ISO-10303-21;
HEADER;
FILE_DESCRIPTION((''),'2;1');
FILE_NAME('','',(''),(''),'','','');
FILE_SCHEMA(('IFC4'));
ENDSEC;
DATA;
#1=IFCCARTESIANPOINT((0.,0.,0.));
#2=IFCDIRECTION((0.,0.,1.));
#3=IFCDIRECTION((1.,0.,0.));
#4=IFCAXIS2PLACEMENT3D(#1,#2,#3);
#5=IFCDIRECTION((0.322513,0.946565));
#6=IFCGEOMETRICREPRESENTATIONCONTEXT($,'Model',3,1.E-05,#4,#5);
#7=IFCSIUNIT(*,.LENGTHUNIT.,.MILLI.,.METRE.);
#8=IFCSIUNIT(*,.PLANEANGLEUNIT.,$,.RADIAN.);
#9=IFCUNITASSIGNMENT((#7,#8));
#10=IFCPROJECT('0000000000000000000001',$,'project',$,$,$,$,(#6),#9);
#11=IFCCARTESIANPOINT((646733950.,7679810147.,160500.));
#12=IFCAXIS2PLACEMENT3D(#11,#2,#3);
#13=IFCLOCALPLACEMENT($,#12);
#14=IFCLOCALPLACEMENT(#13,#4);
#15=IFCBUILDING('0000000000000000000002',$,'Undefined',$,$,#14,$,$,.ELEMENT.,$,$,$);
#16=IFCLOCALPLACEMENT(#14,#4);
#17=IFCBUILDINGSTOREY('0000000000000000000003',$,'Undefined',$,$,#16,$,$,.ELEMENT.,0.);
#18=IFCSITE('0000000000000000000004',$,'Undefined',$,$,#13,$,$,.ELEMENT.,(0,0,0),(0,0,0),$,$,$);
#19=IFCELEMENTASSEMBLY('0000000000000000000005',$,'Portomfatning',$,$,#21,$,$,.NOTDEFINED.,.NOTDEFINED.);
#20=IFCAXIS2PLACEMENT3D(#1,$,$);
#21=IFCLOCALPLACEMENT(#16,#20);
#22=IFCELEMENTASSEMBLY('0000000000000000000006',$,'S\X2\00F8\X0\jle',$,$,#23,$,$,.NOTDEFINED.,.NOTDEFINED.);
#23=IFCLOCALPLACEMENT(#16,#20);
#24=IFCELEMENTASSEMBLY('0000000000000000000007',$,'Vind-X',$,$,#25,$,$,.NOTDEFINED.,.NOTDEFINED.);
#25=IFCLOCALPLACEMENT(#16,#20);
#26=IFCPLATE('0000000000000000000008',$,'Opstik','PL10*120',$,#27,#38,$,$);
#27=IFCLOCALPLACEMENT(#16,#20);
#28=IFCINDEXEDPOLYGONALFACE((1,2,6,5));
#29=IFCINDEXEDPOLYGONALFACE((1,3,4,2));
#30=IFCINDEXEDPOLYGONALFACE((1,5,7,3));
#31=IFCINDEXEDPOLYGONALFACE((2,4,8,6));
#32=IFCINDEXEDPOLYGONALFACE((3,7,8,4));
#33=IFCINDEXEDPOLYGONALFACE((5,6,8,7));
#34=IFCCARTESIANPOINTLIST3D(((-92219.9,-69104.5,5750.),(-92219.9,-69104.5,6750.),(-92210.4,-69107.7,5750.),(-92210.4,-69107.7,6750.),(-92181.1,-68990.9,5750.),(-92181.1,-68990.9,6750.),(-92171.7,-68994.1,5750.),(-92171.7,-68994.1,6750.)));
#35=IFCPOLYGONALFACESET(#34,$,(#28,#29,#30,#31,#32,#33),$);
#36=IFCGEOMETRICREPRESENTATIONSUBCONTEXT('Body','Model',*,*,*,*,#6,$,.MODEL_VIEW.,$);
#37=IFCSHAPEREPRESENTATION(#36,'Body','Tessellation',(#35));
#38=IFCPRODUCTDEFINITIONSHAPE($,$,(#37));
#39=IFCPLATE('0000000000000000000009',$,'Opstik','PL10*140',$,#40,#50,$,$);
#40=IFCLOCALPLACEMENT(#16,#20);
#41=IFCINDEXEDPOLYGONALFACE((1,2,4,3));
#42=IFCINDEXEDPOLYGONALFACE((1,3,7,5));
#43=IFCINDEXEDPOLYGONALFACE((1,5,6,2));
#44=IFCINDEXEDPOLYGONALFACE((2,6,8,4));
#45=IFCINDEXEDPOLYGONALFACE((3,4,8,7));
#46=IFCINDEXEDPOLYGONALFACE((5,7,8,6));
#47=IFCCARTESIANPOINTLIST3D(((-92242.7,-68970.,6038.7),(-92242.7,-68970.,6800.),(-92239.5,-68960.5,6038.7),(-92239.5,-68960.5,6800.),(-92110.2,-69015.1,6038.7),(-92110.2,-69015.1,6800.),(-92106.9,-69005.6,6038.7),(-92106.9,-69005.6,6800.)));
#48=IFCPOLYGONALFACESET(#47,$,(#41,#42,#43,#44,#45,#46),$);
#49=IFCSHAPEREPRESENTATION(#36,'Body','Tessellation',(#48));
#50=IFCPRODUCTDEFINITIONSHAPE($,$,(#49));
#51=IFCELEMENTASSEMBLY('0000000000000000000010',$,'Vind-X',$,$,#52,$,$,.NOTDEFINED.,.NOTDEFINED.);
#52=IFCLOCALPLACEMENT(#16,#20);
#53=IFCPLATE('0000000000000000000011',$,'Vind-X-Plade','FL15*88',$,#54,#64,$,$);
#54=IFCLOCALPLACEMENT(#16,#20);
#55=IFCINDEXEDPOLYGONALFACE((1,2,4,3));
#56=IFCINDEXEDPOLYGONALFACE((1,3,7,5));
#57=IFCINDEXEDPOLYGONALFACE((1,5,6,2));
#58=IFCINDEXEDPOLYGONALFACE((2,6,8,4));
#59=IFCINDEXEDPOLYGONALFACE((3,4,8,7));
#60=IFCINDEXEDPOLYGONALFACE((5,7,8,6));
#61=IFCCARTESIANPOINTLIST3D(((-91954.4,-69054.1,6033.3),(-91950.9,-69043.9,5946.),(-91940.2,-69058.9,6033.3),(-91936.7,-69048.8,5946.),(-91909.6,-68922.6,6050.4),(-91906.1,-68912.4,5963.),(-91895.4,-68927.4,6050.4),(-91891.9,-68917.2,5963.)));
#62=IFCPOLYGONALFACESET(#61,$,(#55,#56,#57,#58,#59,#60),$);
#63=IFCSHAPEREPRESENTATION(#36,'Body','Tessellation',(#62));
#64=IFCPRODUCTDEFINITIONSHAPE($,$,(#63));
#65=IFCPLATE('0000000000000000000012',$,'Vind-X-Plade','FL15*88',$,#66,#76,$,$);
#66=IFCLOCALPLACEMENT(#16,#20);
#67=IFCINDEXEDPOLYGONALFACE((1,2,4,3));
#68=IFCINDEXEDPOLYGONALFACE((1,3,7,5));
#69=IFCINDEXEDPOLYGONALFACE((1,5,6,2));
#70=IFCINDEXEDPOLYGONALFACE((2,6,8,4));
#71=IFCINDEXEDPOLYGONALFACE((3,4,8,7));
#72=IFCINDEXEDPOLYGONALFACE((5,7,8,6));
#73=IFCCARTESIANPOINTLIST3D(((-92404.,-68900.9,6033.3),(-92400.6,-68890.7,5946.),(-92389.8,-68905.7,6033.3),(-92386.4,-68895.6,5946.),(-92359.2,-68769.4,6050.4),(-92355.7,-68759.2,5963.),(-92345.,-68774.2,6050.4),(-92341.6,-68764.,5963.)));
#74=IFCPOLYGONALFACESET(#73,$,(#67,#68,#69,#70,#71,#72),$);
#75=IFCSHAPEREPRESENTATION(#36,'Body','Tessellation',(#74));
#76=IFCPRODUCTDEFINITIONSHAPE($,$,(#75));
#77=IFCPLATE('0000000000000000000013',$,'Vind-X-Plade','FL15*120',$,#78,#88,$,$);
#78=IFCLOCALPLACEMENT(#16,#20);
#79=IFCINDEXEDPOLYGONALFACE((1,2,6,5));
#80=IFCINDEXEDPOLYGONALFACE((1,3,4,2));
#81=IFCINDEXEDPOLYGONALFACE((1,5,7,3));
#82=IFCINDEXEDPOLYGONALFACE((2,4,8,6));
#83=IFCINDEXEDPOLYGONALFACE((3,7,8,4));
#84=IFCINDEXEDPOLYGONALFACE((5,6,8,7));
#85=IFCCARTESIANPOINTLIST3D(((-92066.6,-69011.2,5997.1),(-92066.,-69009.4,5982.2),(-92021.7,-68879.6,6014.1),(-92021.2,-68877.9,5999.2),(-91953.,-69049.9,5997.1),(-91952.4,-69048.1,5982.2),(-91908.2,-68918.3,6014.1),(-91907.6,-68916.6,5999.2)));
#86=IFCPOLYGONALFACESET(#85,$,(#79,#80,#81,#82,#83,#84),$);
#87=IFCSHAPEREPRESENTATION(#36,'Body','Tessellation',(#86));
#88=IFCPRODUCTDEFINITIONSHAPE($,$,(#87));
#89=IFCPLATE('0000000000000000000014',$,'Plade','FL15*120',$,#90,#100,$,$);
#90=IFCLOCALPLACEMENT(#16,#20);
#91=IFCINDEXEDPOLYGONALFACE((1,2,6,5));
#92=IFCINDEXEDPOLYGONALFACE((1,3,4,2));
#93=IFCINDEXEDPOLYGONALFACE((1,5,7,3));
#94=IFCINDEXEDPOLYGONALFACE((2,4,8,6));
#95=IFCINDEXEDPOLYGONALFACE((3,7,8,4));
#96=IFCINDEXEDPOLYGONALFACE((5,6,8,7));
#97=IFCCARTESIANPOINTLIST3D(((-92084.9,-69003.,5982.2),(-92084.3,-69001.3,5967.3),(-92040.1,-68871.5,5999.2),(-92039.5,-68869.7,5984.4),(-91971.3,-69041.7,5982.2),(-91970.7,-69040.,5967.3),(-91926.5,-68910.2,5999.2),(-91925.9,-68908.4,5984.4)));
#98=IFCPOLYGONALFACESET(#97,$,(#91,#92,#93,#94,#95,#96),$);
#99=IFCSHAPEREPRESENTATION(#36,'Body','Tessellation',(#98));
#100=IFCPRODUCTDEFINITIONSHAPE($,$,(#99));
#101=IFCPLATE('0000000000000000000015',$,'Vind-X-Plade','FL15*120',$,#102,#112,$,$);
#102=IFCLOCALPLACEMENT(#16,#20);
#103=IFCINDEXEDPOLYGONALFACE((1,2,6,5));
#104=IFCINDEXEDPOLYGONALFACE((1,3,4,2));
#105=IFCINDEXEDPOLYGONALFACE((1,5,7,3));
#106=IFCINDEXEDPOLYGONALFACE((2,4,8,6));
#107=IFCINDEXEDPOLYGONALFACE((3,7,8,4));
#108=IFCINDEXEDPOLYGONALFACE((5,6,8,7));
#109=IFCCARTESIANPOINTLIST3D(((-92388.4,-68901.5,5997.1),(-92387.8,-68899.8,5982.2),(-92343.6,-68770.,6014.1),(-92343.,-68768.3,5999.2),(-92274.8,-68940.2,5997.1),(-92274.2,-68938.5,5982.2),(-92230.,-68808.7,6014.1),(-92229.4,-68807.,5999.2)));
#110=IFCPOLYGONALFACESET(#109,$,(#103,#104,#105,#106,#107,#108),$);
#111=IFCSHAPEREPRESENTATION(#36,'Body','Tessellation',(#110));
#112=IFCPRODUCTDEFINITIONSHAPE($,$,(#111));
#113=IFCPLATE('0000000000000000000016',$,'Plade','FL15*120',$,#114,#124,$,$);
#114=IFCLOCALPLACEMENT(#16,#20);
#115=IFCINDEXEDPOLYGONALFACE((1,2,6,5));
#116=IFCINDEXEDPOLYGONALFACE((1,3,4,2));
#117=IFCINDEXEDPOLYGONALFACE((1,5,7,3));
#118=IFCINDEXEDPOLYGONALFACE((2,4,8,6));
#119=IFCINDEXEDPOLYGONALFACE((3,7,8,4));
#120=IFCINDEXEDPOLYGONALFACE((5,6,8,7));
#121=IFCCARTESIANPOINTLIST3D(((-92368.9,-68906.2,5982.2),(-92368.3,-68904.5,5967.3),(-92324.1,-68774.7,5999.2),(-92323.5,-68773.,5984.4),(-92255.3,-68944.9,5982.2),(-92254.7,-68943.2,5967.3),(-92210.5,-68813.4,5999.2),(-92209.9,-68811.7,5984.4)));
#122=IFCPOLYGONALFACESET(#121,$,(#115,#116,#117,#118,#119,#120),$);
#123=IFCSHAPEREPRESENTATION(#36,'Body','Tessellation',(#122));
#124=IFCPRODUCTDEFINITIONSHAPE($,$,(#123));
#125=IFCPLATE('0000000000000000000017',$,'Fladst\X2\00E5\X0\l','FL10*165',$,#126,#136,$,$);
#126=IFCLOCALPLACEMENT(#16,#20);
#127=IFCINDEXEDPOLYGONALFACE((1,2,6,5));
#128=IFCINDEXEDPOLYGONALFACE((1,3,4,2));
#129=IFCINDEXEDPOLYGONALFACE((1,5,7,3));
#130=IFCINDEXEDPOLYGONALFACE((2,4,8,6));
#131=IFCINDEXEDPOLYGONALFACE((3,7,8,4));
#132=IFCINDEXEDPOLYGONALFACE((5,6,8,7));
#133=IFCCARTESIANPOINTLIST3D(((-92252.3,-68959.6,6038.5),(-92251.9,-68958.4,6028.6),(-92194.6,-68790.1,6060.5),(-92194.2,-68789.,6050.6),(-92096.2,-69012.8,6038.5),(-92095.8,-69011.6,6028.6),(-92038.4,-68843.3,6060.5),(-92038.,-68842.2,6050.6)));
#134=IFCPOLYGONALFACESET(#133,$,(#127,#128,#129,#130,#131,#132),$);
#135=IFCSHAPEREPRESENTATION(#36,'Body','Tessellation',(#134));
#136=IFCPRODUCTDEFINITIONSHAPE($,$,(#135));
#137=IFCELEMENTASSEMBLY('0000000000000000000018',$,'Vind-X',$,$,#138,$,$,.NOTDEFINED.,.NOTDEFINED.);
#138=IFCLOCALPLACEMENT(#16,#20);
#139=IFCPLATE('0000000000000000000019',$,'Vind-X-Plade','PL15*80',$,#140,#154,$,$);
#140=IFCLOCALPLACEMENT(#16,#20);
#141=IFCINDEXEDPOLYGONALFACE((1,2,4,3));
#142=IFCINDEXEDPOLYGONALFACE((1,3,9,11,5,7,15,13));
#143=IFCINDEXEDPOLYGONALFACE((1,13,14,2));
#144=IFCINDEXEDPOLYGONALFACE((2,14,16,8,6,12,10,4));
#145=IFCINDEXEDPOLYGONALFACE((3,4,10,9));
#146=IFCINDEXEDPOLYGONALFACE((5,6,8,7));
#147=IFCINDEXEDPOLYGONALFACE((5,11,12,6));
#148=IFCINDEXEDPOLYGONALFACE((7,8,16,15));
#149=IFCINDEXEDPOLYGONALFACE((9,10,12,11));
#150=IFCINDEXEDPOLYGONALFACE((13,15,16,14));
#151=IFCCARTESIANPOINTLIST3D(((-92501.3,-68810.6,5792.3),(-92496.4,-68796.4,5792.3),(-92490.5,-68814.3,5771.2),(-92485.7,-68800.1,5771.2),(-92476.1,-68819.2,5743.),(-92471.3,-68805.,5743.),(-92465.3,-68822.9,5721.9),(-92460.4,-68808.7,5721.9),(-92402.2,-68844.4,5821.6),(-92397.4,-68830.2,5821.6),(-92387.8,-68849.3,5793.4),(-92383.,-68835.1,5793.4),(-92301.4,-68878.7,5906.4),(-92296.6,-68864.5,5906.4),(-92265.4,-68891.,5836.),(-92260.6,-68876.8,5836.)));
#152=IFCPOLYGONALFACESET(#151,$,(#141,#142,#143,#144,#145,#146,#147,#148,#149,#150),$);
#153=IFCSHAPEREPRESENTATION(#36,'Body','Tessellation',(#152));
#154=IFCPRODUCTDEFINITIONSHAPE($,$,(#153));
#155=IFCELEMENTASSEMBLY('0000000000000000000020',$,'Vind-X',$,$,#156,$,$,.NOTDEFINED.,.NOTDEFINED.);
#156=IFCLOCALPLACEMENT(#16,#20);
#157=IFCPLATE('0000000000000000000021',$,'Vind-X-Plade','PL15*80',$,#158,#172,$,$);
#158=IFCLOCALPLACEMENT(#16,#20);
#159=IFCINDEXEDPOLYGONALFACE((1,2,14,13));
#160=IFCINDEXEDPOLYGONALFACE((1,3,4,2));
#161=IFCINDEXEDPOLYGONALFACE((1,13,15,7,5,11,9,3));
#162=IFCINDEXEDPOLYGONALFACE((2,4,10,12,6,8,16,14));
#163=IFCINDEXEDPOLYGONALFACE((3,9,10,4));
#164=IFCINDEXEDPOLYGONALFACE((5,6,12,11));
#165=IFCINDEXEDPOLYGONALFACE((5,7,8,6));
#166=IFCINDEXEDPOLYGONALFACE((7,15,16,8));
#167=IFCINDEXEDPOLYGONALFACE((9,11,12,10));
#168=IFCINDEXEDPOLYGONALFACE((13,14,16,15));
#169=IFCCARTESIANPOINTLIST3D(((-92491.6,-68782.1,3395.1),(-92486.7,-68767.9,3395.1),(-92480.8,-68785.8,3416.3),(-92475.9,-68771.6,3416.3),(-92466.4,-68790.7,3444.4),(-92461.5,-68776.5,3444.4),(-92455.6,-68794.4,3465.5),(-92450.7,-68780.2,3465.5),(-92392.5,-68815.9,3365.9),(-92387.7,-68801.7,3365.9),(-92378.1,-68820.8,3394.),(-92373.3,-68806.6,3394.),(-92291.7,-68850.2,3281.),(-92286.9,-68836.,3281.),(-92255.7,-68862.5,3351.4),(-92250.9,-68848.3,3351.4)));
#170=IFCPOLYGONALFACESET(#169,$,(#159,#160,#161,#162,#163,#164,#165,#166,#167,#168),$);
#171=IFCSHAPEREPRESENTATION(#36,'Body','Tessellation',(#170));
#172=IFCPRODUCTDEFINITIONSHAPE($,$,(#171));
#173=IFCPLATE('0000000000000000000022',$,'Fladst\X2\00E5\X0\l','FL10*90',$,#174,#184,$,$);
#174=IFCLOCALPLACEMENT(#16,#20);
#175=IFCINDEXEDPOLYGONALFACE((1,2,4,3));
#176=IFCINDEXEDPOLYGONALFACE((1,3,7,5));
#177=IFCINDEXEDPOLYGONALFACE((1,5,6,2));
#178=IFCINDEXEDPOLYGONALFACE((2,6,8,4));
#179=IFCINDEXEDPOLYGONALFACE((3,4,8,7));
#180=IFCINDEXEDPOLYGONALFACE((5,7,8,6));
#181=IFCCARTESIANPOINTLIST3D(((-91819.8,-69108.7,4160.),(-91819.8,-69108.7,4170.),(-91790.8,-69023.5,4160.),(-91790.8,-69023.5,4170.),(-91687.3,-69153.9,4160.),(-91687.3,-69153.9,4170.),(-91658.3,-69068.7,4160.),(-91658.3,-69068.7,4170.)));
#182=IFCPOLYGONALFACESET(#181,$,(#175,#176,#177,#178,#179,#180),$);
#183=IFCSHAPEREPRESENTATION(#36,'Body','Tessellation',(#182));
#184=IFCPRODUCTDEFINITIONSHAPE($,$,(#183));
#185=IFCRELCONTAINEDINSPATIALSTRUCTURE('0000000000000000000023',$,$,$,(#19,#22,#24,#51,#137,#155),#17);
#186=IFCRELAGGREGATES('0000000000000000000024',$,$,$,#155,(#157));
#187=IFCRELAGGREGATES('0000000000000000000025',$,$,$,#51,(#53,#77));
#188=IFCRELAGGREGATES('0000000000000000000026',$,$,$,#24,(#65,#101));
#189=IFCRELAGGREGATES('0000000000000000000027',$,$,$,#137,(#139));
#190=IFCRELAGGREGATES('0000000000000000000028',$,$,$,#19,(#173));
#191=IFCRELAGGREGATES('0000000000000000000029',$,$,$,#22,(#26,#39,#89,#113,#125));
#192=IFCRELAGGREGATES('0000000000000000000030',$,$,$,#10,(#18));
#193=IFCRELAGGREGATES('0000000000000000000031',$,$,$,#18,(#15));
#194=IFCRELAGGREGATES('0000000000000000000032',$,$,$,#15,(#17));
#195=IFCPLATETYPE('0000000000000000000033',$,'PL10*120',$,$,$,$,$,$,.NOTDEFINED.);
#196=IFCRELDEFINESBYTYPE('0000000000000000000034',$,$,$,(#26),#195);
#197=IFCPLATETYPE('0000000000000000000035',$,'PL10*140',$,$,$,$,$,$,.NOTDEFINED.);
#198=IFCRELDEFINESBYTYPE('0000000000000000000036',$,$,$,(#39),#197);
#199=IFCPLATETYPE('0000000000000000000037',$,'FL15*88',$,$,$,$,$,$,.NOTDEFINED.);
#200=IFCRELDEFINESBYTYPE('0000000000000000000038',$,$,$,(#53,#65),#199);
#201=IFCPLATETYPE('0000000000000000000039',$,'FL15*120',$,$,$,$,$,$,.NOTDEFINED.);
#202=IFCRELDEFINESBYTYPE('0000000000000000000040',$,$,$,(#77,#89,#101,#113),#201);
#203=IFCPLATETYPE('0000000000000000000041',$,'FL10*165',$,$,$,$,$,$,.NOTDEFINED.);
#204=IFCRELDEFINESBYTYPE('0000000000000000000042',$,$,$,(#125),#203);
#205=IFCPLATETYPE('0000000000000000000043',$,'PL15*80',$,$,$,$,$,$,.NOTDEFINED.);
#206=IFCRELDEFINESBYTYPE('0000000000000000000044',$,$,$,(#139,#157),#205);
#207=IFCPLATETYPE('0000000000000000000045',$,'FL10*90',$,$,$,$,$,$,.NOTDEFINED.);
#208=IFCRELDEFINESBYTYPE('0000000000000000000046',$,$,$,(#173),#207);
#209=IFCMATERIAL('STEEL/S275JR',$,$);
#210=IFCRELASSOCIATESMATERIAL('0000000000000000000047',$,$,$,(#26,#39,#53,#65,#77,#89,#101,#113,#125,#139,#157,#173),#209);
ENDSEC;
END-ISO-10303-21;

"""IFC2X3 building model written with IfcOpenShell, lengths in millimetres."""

from ifc_helpers import new_model, si_unit, direction, frame, origin_with_axes, place, context, subcontext, project, spatial, polyline, outline, extrude, boolean, material, type_object, element, aggregate, save


model = new_model("IFC2X3")

# Units and contexts
model_context = context("Model", 3, precision=1e-05, world=origin_with_axes(), true_north=direction((0.322513, 0.946565)))
body_context = subcontext(model_context, "Body", "Model", "MODEL_VIEW")
ifc_project = project(units=[si_unit("LENGTHUNIT", "METRE", prefix="MILLI"), si_unit("PLANEANGLEUNIT", "RADIAN")], contexts=[model_context])

# Site, building, storey
site_placement = place(None, frame((646733950.0, 7679810147.0, 160500.0), z_axis=(0.0, 0.0, 1.0), x_axis=(1.0, 0.0, 0.0)))
site = spatial("IfcSite", under=ifc_project, at=site_placement, Name="Undefined", CompositionType="ELEMENT", RefLatitude=(0, 0, 0), RefLongitude=(0, 0, 0))
building_placement = place(site_placement, origin_with_axes())
building = spatial("IfcBuilding", under=site, at=building_placement, Name="Undefined", CompositionType="ELEMENT")
storey_placement = place(building_placement, origin_with_axes())
storey = spatial("IfcBuildingStorey", under=building, at=storey_placement, Name="Undefined", CompositionType="ELEMENT", Elevation=0.0)

# Element assemblies
assembly_1_placement = place(storey_placement, origin_with_axes())
assembly_1 = element("IfcElementAssembly", 1, at=assembly_1_placement, inside=storey, Name="Portomfatning", AssemblyPlace="NOTDEFINED", PredefinedType="NOTDEFINED")
assembly_2_placement = place(storey_placement, origin_with_axes())
assembly_2 = element("IfcElementAssembly", 2, at=assembly_2_placement, inside=storey, Name="Søjle", AssemblyPlace="NOTDEFINED", PredefinedType="NOTDEFINED")

# Element assembly
assembly_3_placement = place(storey_placement, origin_with_axes())
assembly_3 = element("IfcElementAssembly", 3, at=assembly_3_placement, inside=storey, Name="Vind-X", AssemblyPlace="NOTDEFINED", PredefinedType="NOTDEFINED")

# Plates
ifc_material_1 = material(Name="STEEL/S275JR")
plate_type_1 = type_object("IfcPlateType", Name="PL10*120", PredefinedType="NOTDEFINED")
plate_1_placement = place(assembly_2_placement, frame((-92176.4, -68992.5, 5750.0), z_axis=(0.946565, -0.322513, 0.0), x_axis=(0.0, 0.0, 1.0)))
plate_1 = element("IfcPlate", 4, at=plate_1_placement, type_object=plate_type_1, material=ifc_material_1, Name="Opstik", Description="PL10*120", context=body_context, shape_type="SweptSolid", body=[
    extrude(outline(polyline([(0.0, 0.0), (1000.0, 0.0), (1000.0, 120.0), (1000.0, 120.0), (0.0, 120.0), (0.0, 120.0), (0.0, 0.0)])), frame((0.0, 0.0, -5.0), z_axis=(0.0, 0.0, 1.0), x_axis=(1.0, 0.0, 0.0)), (0.0, 0.0, 1.0), 10.0),
])
plate_type_2 = type_object("IfcPlateType", Name="PL10*140", PredefinedType="NOTDEFINED")
plate_2_placement = place(assembly_2_placement, frame((-92108.5, -69010.4, 6038.7), z_axis=(-0.322513, -0.946565, 0.0), x_axis=(0.0, 0.0, 1.0)))
plate_2 = element("IfcPlate", 5, at=plate_2_placement, type_object=plate_type_2, material=ifc_material_1, Name="Opstik", Description="PL10*140", context=body_context, shape_type="SweptSolid", body=[
    extrude(outline(polyline([(0.0, 0.0), (761.3, 0.0), (761.3, 0.0), (761.3, 140.0), (761.3, 140.0), (0.0, 140.0), (0.0, 0.0)])), frame((0.0, 0.0, -5.0), z_axis=(0.0, 0.0, 1.0), x_axis=(1.0, 0.0, 0.0)), (0.0, 0.0, 1.0), 10.0),
])

# Element assembly, plate
assembly_4_placement = place(storey_placement, origin_with_axes())
assembly_4 = element("IfcElementAssembly", 6, at=assembly_4_placement, inside=storey, Name="Vind-X", AssemblyPlace="NOTDEFINED", PredefinedType="NOTDEFINED")
plate_type_3 = type_object("IfcPlateType", Name="FL15*88", PredefinedType="NOTDEFINED")
plate_3_placement = place(assembly_4_placement, frame((-91899.0, -68914.8, 5963.0), z_axis=(-0.946565, 0.322513, 0.0), x_axis=(-0.320109, -0.93951, -0.121869)))
plate_3 = element("IfcPlate", 7, at=plate_3_placement, type_object=plate_type_3, material=ifc_material_1, Name="Vind-X-Plade", Description="FL15*88", context=body_context, shape_type="SweptSolid", body=[
    extrude(outline(polyline([(0.0, 0.0), (140.0, 0.0), (140.0, 88.0), (0.0, 88.0), (0.0, 0.0)])), frame((0.0, 0.0, -7.5), z_axis=(0.0, 0.0, 1.0), x_axis=(1.0, 0.0, 0.0)), (0.0, 0.0, 1.0), 15.0),
])

# Plates
plate_4_placement = place(assembly_3_placement, frame((-92393.5, -68893.2, 5946.0), z_axis=(0.946565, -0.322513, 0.0), x_axis=(0.320109, 0.93951, 0.121869)))
plate_4 = element("IfcPlate", 8, at=plate_4_placement, type_object=plate_type_3, material=ifc_material_1, Name="Vind-X-Plade", Description="FL15*88", context=body_context, shape_type="SweptSolid", body=[
    extrude(outline(polyline([(0.0, 0.0), (140.0, 0.0), (140.0, 88.0), (0.0, 88.0), (0.0, 0.0)])), frame((0.0, 0.0, -7.5), z_axis=(0.0, 0.0, 1.0), x_axis=(1.0, 0.0, 0.0)), (0.0, 0.0, 1.0), 15.0),
])
plate_type_4 = type_object("IfcPlateType", Name="FL15*120", PredefinedType="NOTDEFINED")
plate_5_placement = place(assembly_4_placement, frame((-92043.9, -68944.5, 5998.2), z_axis=(0.039304, 0.115357, -0.992546), x_axis=(0.946565, -0.322513, 0.0)))
plate_5 = element("IfcPlate", 9, at=plate_5_placement, type_object=plate_type_4, material=ifc_material_1, Name="Vind-X-Plade", Description="FL15*120", context=body_context, shape_type="SweptSolid", body=[
    extrude(outline(polyline([(0.0, -70.0), (0.0, 70.0), (120.0, 70.0), (120.0, -70.0), (0.0, -70.0)])), frame((0.0, 0.0, -7.5), z_axis=(0.0, 0.0, 1.0), x_axis=(1.0, 0.0, 0.0)), (0.0, 0.0, 1.0), 15.0),
])
plate_6_placement = place(assembly_2_placement, frame((-92039.8, -68870.6, 5991.8), z_axis=(-0.039304, -0.115357, 0.992546), x_axis=(-0.320109, -0.93951, -0.121869)))
plate_6 = element("IfcPlate", 10, at=plate_6_placement, type_object=plate_type_4, material=ifc_material_1, Name="Plade", Description="FL15*120", context=body_context, shape_type="SweptSolid", body=[
    extrude(outline(polyline([(0.0, 0.0), (140.0, 0.0), (140.0, 120.0), (0.0, 120.0), (0.0, 0.0)])), frame((0.0, 0.0, -7.5), z_axis=(0.0, 0.0, 1.0), x_axis=(1.0, 0.0, 0.0)), (0.0, 0.0, 1.0), 15.0),
])
plate_7_placement = place(assembly_3_placement, frame((-92252.1, -68873.6, 5998.2), z_axis=(0.039304, 0.115357, -0.992546), x_axis=(-0.946565, 0.322513, 0.0)))
plate_7 = element("IfcPlate", 11, at=plate_7_placement, type_object=plate_type_4, material=ifc_material_1, Name="Vind-X-Plade", Description="FL15*120", context=body_context, shape_type="SweptSolid", body=[
    extrude(outline(polyline([(0.0, -70.0), (0.0, 70.0), (120.0, 70.0), (120.0, -70.0), (0.0, -70.0)])), frame((0.0, 0.0, -7.5), z_axis=(0.0, 0.0, 1.0), x_axis=(1.0, 0.0, 0.0)), (0.0, 0.0, 1.0), 15.0),
])
plate_8_placement = place(assembly_2_placement, frame((-92255.0, -68944.1, 5974.7), z_axis=(-0.039304, -0.115357, 0.992546), x_axis=(0.320109, 0.93951, 0.121869)))
plate_8 = element("IfcPlate", 12, at=plate_8_placement, type_object=plate_type_4, material=ifc_material_1, Name="Plade", Description="FL15*120", context=body_context, shape_type="SweptSolid", body=[
    extrude(outline(polyline([(0.0, 0.0), (140.0, 0.0), (140.0, 120.0), (0.0, 120.0), (0.0, 0.0)])), frame((0.0, 0.0, -7.5), z_axis=(0.0, 0.0, 1.0), x_axis=(1.0, 0.0, 0.0)), (0.0, 0.0, 1.0), 15.0),
])
plate_type_5 = type_object("IfcPlateType", Name="FL10*165", PredefinedType="NOTDEFINED")
plate_9_placement = place(assembly_2_placement, frame((-92174.1, -68985.6, 6033.6), z_axis=(0.039304, 0.115357, -0.992546), x_axis=(0.320109, 0.93951, 0.121869)))
plate_9 = element("IfcPlate", 13, at=plate_9_placement, type_object=plate_type_5, material=ifc_material_1, Name="Fladstål", Description="FL10*165", context=body_context, shape_type="SweptSolid", body=[
    extrude(outline(polyline([(0.0, -82.5), (0.0, 82.5), (180.4, 82.5), (180.4, -82.5), (0.0, -82.5)])), frame((0.0, 0.0, -5.0), z_axis=(0.0, 0.0, 1.0), x_axis=(1.0, 0.0, 0.0)), (0.0, 0.0, 1.0), 10.0),
])

# Element assemblies, plates
assembly_5_placement = place(storey_placement, origin_with_axes())
assembly_5 = element("IfcElementAssembly", 14, at=assembly_5_placement, inside=storey, Name="Vind-X", AssemblyPlace="NOTDEFINED", PredefinedType="NOTDEFINED")
plate_type_6 = type_object("IfcPlateType", Name="PL15*80", PredefinedType="NOTDEFINED")
plate_10_placement = place(assembly_5_placement, frame((-92263.0, -68883.9, 5836.0), z_axis=(-0.322513, -0.946565, 0.0), x_axis=(-0.450012, 0.153328, 0.879761)))
plate_10 = element("IfcPlate", 15, at=plate_10_placement, type_object=plate_type_6, material=ifc_material_1, Name="Vind-X-Plade", Description="PL15*80", context=body_context, shape_type="CSG", body=[
    boolean("DIFFERENCE", extrude(outline(polyline([(0.0, 0.0), (80.0, 0.0), (80.0, 240.0), (0.0, 240.0), (0.0, 0.0)])), frame((0.0, 0.0, -7.5), z_axis=(0.0, 0.0, 1.0), x_axis=(1.0, 0.0, 0.0)), (0.0, 0.0, 1.0), 15.0), extrude(outline(polyline([(0.0, 0.0), (106.0, 0.0), (106.0, 32.0), (0.0, 32.0), (0.0, 0.0)])), frame((56.0, 240.0, 8.5), z_axis=(0.0, 0.0, -1.0), x_axis=(0.0, -1.0, 0.0)), (0.0, 0.0, 1.0), 17.0)),
])
assembly_6_placement = place(storey_placement, origin_with_axes())
assembly_6 = element("IfcElementAssembly", 16, at=assembly_6_placement, inside=storey, Name="Vind-X", AssemblyPlace="NOTDEFINED", PredefinedType="NOTDEFINED")
plate_11_placement = place(assembly_6_placement, frame((-92289.3, -68843.1, 3281.0), z_axis=(-0.322513, -0.946565, 0.0), x_axis=(0.450012, -0.153328, 0.879761)))
plate_11 = element("IfcPlate", 17, at=plate_11_placement, type_object=plate_type_6, material=ifc_material_1, Name="Vind-X-Plade", Description="PL15*80", context=body_context, shape_type="CSG", body=[
    boolean("DIFFERENCE", extrude(outline(polyline([(0.0, 0.0), (80.0, 0.0), (80.0, 240.0), (0.0, 240.0), (0.0, 0.0)])), frame((0.0, 0.0, -7.5), z_axis=(0.0, 0.0, 1.0), x_axis=(1.0, 0.0, 0.0)), (0.0, 0.0, 1.0), 15.0), extrude(outline(polyline([(0.0, 0.0), (106.0, 0.0), (106.0, 32.0), (0.0, 32.0), (0.0, 0.0)])), frame((56.0, 240.0, 8.5), z_axis=(0.0, 0.0, -1.0), x_axis=(0.0, -1.0, 0.0)), (0.0, 0.0, 1.0), 17.0)),
])
aggregate(assembly_6, [plate_11])

# Plate
plate_type_7 = type_object("IfcPlateType", Name="FL10*90", PredefinedType="NOTDEFINED")
plate_12_placement = place(assembly_1_placement, frame((-91672.8, -69111.3, 4165.0), z_axis=(0.0, 0.0, 1.0), x_axis=(-0.946565, 0.322513, 0.0)))
plate_12 = element("IfcPlate", 18, at=plate_12_placement, type_object=plate_type_7, material=ifc_material_1, Name="Fladstål", Description="FL10*90", context=body_context, shape_type="SweptSolid", body=[
    extrude(outline(polyline([(0.0, -45.0), (0.0, 45.0), (140.0, 45.0), (140.0, -45.0), (0.0, -45.0)])), frame((0.0, 0.0, -5.0), z_axis=(0.0, 0.0, 1.0), x_axis=(1.0, 0.0, 0.0)), (0.0, 0.0, 1.0), 10.0),
])

aggregate(assembly_4, [plate_3, plate_5])
aggregate(assembly_3, [plate_4, plate_7])
aggregate(assembly_5, [plate_10])
aggregate(assembly_1, [plate_12])
aggregate(assembly_2, [plate_1, plate_2, plate_6, plate_8, plate_9])

save(model, "model.ifc")
